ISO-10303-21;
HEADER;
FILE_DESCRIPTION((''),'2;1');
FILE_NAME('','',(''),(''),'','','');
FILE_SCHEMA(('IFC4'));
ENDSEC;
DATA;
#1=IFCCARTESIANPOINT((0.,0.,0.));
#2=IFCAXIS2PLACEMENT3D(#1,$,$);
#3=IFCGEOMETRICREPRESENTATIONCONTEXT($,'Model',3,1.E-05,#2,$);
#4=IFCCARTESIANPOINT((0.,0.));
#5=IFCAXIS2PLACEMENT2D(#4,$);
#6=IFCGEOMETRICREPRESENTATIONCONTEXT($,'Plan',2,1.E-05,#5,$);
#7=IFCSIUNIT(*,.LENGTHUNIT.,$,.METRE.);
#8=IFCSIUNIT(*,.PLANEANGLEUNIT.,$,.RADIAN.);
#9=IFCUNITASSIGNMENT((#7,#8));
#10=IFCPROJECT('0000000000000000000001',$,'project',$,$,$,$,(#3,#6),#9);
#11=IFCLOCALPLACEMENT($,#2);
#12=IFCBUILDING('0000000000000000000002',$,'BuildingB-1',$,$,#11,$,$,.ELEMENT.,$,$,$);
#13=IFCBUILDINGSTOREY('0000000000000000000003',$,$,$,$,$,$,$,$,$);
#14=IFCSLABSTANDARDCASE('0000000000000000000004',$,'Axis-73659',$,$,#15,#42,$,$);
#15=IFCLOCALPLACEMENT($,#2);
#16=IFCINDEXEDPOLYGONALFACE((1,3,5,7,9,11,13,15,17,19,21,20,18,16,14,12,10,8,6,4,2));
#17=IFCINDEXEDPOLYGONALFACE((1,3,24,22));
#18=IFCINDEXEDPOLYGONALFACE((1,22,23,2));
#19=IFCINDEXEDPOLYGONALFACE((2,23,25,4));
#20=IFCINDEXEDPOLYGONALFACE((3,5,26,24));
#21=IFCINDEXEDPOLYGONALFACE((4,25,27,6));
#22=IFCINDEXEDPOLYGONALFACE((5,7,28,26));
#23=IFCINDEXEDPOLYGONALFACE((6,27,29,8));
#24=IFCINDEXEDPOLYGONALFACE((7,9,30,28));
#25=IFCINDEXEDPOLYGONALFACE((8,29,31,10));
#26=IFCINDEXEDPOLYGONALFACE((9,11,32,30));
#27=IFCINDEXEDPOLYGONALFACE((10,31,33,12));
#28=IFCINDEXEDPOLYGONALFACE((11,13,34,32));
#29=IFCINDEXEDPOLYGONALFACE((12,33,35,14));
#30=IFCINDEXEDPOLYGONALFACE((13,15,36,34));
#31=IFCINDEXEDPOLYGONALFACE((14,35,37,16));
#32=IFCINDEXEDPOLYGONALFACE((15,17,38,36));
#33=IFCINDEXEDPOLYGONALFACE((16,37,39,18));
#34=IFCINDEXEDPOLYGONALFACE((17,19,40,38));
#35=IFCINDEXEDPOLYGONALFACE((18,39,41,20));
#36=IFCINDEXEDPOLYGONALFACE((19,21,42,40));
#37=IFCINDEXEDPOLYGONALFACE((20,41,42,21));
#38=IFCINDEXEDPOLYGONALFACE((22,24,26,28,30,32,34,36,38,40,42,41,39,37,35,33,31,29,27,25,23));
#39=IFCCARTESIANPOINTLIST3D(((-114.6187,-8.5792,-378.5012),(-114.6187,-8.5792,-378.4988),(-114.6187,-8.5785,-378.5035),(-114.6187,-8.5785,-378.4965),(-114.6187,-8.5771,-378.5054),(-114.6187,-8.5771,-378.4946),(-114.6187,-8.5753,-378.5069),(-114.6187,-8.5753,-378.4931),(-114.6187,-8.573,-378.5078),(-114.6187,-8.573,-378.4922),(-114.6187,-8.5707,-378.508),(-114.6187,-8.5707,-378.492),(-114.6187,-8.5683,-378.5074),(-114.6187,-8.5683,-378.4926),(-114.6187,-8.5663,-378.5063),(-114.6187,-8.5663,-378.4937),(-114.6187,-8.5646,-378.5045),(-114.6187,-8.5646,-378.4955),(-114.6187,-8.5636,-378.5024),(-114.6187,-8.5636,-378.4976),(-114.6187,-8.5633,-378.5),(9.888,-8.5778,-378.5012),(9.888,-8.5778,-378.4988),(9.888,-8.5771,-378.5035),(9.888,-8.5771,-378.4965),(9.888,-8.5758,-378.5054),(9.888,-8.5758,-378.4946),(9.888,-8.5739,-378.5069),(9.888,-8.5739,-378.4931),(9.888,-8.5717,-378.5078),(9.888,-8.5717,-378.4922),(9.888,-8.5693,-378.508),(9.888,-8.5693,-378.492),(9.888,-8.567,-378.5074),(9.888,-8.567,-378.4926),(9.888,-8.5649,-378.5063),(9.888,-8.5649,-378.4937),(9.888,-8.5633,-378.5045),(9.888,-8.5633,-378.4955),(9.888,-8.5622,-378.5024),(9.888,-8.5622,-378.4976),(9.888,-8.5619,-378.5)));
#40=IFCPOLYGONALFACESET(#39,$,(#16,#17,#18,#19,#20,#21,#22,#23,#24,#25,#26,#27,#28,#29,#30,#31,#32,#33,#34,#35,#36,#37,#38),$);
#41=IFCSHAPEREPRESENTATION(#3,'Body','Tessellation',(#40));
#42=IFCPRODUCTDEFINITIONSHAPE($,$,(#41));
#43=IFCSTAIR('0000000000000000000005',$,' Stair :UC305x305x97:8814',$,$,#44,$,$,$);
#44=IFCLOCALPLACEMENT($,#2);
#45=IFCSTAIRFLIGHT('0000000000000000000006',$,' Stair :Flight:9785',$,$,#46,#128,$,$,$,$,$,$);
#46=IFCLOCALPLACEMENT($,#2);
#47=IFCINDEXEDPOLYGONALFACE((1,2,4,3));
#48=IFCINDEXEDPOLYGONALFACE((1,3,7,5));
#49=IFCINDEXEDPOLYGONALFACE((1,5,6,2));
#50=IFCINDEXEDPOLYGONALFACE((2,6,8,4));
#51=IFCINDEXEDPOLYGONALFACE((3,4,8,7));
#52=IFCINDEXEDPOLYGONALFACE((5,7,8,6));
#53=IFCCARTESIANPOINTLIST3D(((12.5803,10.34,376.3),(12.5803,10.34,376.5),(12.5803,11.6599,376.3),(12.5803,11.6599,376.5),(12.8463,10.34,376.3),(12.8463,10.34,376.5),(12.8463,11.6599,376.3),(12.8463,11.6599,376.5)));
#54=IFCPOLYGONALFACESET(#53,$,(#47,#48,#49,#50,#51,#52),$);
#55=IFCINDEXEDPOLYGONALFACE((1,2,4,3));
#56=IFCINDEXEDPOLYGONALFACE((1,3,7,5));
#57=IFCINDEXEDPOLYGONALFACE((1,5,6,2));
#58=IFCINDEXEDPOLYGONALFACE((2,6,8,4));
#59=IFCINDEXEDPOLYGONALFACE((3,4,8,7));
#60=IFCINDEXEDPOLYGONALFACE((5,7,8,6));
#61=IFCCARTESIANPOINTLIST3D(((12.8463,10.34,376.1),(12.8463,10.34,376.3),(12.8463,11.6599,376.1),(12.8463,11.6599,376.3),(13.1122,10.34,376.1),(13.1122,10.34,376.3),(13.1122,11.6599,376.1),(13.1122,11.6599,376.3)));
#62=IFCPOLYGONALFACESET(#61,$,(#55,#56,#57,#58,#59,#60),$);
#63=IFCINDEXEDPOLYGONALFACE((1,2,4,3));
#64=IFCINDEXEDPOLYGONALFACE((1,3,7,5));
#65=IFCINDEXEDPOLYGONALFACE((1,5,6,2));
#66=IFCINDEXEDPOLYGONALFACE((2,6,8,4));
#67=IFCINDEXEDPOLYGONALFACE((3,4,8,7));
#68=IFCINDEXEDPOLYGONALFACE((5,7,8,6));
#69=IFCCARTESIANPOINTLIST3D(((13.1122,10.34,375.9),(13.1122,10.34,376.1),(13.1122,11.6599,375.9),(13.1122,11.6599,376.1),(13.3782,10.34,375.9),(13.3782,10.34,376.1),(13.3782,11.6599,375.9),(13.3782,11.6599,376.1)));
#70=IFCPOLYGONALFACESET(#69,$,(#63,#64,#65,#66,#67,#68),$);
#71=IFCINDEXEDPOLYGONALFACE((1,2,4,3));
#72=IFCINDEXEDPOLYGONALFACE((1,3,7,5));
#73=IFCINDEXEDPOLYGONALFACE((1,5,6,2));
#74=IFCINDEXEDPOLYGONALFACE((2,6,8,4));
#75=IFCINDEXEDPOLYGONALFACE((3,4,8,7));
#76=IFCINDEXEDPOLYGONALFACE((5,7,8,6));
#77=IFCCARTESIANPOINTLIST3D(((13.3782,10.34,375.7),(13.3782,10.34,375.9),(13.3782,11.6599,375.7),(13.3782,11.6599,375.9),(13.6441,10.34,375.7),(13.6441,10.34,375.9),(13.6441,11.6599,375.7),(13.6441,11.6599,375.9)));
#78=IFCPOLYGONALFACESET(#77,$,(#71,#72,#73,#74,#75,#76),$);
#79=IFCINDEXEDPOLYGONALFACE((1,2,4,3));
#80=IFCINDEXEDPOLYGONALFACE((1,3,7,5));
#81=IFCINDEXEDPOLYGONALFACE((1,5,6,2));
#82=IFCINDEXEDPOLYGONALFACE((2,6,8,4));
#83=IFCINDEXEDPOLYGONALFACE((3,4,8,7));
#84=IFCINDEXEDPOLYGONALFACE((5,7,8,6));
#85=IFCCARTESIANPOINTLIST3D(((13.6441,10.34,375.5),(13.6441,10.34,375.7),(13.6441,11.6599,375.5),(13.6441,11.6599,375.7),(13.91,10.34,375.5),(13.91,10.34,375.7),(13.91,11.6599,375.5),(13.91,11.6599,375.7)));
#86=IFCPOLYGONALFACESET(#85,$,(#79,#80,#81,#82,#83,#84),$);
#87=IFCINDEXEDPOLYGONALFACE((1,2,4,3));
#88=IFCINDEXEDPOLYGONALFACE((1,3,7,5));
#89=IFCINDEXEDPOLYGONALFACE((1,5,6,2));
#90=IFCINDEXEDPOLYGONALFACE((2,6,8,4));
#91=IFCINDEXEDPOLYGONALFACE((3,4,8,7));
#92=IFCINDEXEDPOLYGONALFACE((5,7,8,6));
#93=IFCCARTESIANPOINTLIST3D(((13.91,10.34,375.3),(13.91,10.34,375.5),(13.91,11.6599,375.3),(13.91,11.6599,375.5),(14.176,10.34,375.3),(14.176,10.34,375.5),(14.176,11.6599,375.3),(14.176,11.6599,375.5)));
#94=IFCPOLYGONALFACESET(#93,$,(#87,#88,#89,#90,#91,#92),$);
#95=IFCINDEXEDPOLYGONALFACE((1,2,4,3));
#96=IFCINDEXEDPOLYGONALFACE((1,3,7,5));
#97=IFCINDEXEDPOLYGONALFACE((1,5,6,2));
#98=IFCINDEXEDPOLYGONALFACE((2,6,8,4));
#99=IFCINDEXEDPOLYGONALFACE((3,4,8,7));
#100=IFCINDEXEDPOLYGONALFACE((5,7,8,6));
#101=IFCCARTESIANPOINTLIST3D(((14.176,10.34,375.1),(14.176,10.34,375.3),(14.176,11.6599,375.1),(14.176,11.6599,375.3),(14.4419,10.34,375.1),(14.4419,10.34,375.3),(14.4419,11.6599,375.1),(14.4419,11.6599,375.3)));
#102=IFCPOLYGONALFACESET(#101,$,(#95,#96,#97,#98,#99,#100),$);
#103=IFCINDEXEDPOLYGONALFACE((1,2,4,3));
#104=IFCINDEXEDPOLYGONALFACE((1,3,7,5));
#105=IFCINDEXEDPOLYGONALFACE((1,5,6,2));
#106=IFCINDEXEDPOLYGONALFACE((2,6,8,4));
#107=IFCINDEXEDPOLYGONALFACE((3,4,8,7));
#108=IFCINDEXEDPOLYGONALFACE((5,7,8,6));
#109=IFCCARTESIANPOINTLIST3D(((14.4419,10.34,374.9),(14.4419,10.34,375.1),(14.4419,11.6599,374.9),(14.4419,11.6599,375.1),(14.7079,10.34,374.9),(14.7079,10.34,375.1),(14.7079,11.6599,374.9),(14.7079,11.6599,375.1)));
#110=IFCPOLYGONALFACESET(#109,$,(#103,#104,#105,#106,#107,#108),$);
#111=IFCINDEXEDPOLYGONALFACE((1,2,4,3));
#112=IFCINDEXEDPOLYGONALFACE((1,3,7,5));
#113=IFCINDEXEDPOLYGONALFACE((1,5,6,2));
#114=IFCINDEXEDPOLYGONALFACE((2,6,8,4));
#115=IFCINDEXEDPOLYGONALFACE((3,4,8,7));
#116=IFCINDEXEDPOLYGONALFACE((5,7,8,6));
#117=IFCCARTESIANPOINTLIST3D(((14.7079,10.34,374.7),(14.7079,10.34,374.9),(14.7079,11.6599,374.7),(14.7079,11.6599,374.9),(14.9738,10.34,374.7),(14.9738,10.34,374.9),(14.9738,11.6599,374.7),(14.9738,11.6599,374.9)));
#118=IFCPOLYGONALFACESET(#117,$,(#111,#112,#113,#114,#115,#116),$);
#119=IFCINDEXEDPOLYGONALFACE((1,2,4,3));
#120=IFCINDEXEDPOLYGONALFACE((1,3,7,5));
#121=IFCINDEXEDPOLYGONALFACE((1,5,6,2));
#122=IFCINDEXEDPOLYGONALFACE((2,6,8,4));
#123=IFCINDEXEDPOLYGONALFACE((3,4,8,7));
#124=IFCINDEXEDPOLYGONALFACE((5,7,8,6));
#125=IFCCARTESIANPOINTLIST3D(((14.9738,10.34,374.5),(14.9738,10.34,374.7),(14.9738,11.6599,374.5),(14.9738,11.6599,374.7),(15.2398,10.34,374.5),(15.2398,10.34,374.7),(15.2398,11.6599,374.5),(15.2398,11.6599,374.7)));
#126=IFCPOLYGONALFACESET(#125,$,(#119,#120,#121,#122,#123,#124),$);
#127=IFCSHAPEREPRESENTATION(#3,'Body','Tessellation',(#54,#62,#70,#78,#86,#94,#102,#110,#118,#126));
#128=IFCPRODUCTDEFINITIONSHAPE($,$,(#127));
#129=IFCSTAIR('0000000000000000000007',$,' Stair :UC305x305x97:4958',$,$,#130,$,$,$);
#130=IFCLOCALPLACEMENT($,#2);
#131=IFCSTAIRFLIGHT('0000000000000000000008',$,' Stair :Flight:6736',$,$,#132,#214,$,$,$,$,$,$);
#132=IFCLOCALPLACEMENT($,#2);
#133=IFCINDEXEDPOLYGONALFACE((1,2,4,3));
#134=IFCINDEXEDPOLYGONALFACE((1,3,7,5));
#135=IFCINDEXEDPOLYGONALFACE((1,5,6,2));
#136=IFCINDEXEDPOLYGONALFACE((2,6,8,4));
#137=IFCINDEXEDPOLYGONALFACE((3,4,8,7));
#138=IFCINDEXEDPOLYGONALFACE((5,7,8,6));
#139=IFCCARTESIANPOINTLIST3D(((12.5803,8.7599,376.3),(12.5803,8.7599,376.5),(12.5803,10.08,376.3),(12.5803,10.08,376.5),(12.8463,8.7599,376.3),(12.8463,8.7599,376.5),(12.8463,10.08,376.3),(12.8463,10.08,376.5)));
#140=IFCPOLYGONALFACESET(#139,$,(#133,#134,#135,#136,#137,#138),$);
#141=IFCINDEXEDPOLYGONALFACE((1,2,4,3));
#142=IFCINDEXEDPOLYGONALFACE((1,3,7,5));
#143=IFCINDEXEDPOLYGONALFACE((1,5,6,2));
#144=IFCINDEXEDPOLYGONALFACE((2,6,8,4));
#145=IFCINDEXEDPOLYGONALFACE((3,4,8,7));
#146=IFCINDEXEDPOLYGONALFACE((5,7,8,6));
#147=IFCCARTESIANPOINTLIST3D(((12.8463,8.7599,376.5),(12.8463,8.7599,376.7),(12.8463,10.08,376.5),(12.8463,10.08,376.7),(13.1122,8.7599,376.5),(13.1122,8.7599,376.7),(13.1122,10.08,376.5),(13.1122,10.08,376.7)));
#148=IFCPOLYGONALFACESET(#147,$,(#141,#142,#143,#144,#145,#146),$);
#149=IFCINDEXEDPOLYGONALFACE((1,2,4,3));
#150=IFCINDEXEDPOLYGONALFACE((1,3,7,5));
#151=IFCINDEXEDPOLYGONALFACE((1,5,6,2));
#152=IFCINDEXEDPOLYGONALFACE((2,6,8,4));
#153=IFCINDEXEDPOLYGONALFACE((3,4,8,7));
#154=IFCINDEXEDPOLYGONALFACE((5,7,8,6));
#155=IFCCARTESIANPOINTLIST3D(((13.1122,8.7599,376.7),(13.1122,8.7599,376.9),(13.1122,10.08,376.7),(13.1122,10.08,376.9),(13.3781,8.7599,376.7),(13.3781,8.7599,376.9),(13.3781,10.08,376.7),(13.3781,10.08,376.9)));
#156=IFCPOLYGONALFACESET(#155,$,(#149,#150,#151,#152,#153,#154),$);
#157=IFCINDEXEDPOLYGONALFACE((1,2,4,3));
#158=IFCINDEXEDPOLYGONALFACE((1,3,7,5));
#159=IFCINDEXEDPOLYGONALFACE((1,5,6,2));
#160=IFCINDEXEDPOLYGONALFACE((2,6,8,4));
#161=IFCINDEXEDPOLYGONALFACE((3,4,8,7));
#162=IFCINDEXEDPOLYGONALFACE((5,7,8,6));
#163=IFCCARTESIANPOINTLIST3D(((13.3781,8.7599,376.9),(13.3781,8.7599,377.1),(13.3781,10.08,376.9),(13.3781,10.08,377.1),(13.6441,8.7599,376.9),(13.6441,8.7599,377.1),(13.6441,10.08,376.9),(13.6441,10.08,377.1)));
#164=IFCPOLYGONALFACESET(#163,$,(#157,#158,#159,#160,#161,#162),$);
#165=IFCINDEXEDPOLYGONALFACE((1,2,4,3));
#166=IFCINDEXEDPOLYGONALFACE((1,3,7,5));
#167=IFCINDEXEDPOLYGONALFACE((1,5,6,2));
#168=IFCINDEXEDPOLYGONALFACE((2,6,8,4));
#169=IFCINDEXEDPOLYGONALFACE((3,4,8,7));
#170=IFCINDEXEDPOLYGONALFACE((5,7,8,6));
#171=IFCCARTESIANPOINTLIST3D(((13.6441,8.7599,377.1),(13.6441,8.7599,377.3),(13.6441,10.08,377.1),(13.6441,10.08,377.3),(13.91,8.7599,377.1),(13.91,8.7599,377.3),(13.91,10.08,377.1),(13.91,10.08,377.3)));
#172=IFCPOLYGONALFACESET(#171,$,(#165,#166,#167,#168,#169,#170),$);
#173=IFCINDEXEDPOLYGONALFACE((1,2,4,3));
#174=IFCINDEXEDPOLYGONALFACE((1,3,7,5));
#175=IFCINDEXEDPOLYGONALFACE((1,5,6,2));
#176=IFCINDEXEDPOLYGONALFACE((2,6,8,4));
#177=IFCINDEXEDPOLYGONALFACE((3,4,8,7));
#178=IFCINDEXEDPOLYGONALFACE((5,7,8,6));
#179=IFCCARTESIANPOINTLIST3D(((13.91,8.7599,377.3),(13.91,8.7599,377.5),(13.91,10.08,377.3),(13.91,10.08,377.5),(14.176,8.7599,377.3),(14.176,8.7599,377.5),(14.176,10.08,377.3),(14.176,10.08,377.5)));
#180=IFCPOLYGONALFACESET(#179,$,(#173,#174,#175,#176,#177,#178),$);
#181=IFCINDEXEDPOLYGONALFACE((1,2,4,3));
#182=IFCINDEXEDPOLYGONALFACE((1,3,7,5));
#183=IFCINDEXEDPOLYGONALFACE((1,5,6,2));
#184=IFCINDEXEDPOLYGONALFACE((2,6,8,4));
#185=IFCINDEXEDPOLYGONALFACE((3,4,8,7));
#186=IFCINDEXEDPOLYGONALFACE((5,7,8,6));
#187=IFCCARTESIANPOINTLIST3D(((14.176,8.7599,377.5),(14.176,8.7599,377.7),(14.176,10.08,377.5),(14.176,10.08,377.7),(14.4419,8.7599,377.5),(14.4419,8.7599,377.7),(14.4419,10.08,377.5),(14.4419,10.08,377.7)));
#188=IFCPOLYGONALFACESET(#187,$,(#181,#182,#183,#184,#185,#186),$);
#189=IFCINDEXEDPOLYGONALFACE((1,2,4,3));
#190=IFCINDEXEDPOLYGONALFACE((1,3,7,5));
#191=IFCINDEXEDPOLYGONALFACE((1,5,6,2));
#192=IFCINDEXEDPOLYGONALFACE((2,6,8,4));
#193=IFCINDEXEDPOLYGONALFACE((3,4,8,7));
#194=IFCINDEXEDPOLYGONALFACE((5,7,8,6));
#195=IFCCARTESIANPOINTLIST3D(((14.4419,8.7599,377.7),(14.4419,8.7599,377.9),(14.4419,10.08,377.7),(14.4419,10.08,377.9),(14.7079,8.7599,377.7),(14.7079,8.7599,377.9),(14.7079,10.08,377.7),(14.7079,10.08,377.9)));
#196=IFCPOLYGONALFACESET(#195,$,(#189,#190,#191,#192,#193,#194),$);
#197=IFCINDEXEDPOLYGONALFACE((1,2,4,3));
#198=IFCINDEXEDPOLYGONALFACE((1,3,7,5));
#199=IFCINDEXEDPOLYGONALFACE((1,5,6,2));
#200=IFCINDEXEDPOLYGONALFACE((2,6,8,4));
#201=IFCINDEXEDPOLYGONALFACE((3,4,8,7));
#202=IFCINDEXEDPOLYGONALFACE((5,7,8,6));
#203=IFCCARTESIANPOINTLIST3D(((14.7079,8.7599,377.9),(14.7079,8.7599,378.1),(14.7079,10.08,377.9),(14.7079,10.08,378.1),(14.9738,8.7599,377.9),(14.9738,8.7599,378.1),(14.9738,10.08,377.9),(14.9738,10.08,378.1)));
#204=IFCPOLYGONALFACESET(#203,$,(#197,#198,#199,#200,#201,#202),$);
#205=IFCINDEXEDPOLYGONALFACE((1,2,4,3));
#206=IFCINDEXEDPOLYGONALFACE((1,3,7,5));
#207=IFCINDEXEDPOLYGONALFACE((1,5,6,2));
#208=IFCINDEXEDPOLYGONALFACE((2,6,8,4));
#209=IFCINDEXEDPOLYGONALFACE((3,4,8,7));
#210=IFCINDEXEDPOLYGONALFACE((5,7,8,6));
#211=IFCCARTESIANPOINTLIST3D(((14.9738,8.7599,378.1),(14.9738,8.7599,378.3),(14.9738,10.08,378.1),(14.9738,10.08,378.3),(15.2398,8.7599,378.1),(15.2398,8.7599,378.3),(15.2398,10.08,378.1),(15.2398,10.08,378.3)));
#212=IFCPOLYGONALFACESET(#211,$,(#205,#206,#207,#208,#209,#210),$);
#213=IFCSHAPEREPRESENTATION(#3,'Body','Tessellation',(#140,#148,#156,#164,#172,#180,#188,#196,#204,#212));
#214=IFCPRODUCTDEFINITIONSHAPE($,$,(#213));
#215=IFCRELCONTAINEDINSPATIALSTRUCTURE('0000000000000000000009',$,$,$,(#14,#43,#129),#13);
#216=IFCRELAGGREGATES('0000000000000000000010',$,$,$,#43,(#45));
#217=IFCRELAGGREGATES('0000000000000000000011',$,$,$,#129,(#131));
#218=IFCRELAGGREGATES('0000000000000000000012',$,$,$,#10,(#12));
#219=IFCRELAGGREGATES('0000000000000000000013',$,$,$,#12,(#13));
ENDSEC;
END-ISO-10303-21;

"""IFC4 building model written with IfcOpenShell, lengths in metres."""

from ifc_helpers import new_model, entity, si_unit, frame, origin, origin_2d, place, context, project, spatial, polyline, outline, extrude, element, aggregate, save


model = new_model("IFC4")

# Units and contexts
model_context = context("Model", 3, precision=1e-05, world=origin())
plan_context = context("Plan", 2, precision=1e-05, world=origin_2d())
ifc_project = project(units=[si_unit("LENGTHUNIT", "METRE"), si_unit("PLANEANGLEUNIT", "RADIAN")], contexts=[model_context, plan_context])

# Building, storey
building_placement = place(None, origin())
building = spatial("IfcBuilding", under=ifc_project, at=building_placement, Name="BuildingB-1", CompositionType="ELEMENT")
storey = spatial("IfcBuildingStorey", under=building)

# Slab
element("IfcSlabStandardCase", 1, inside=storey, Name="Axis-73659", context=model_context, shape_type="AdvancedSweptSolid", body=[
    entity("IfcSurfaceCurveSweptAreaSolid", entity("IfcCircleProfileDef", "AREA", None, None, 0.008), None, entity("IfcPolyline", [entity("IfcCartesianPoint", [-9.888, 8.5699, 378.5]), entity("IfcCartesianPoint", [114.6187, 8.5713, 378.5])]), None, None, entity("IfcPlane", entity("IfcAxis2Placement3D", entity("IfcCartesianPoint", [-9.888, 8.5699, 378.5]), entity("IfcDirection", [0.0, 0.0, 1.0]), entity("IfcDirection", [1.0, 0.0, 0.0])))),
    entity("IfcSurfaceCurveSweptAreaSolid", entity("IfcCircleProfileDef", "AREA", None, None, 0.008), None, entity("IfcCircle", entity("IfcAxis2Placement2D", entity("IfcCartesianPoint", [-10.1215, 8.5699, 378.5])), 0.35), None, None, entity("IfcPlane", entity("IfcAxis2Placement3D", entity("IfcCartesianPoint", [-10.1215, 8.5699, 378.5]), entity("IfcDirection", [0.0, 0.0, 1.0]), entity("IfcDirection", [1.0, 0.0, 0.0])))),
    entity("IfcSurfaceCurveSweptAreaSolid", entity("IfcCircleProfileDef", "AREA", None, None, 0.008), None, entity("IfcCircle", entity("IfcAxis2Placement2D", entity("IfcCartesianPoint", [114.8522, 8.5713, 378.5])), 0.35), None, None, entity("IfcPlane", entity("IfcAxis2Placement3D", entity("IfcCartesianPoint", [114.8522, 8.5713, 378.5]), entity("IfcDirection", [0.0, 0.0, 1.0]), entity("IfcDirection", [1.0, 0.0, 0.0])))),
])

# Stairs, stair flights
stair_1 = element("IfcStair", 2, inside=storey, Name=" Stair :UC305x305x97:8814")
stair_flight_1 = element("IfcStairFlight", 3, Name=" Stair :Flight:9785", context=model_context, shape_type="SweptSolid", body=[
    extrude(outline(polyline([(12.8463, 11.6599, 376.5), (12.8463, 10.34, 376.5), (12.5803, 10.34, 376.5), (12.5803, 11.6599, 376.5), (12.8463, 11.6599, 376.5)])), origin(), (0.0, 0.0, -1.0), 0.2),
    extrude(outline(polyline([(13.1122, 11.6599, 376.5), (13.1122, 10.34, 376.5), (12.8463, 10.34, 376.5), (12.8463, 11.6599, 376.5), (13.1122, 11.6599, 376.5)])), frame((0.0, 0.0, -0.2)), (0.0, 0.0, -1.0), 0.2),
    extrude(outline(polyline([(13.3782, 11.6599, 376.5), (13.3782, 10.34, 376.5), (13.1122, 10.34, 376.5), (13.1122, 11.6599, 376.5), (13.3782, 11.6599, 376.5)])), frame((0.0, 0.0, -0.4)), (0.0, 0.0, -1.0), 0.2),
    extrude(outline(polyline([(13.6441, 11.6599, 376.5), (13.6441, 10.34, 376.5), (13.3782, 10.34, 376.5), (13.3782, 11.6599, 376.5), (13.6441, 11.6599, 376.5)])), frame((0.0, 0.0, -0.6)), (0.0, 0.0, -1.0), 0.2),
    extrude(outline(polyline([(13.91, 11.6599, 376.5), (13.91, 10.34, 376.5), (13.6441, 10.34, 376.5), (13.6441, 11.6599, 376.5), (13.91, 11.6599, 376.5)])), frame((0.0, 0.0, -0.8)), (0.0, 0.0, -1.0), 0.2),
    extrude(outline(polyline([(14.176, 11.6599, 376.5), (14.176, 10.34, 376.5), (13.91, 10.34, 376.5), (13.91, 11.6599, 376.5), (14.176, 11.6599, 376.5)])), frame((0.0, 0.0, -1.0)), (0.0, 0.0, -1.0), 0.2),
    extrude(outline(polyline([(14.4419, 11.6599, 376.5), (14.4419, 10.34, 376.5), (14.176, 10.34, 376.5), (14.176, 11.6599, 376.5), (14.4419, 11.6599, 376.5)])), frame((0.0, 0.0, -1.2)), (0.0, 0.0, -1.0), 0.2),
    extrude(outline(polyline([(14.7079, 11.6599, 376.5), (14.7079, 10.34, 376.5), (14.4419, 10.34, 376.5), (14.4419, 11.6599, 376.5), (14.7079, 11.6599, 376.5)])), frame((0.0, 0.0, -1.4)), (0.0, 0.0, -1.0), 0.2),
    extrude(outline(polyline([(14.9738, 11.6599, 376.5), (14.9738, 10.34, 376.5), (14.7079, 10.34, 376.5), (14.7079, 11.6599, 376.5), (14.9738, 11.6599, 376.5)])), frame((0.0, 0.0, -1.6)), (0.0, 0.0, -1.0), 0.2),
    extrude(outline(polyline([(15.2398, 11.6599, 376.5), (15.2398, 10.34, 376.5), (14.9738, 10.34, 376.5), (14.9738, 11.6599, 376.5), (15.2398, 11.6599, 376.5)])), frame((0.0, 0.0, -1.8)), (0.0, 0.0, -1.0), 0.2),
])
aggregate(stair_1, [stair_flight_1])
stair_2 = element("IfcStair", 4, inside=storey, Name=" Stair :UC305x305x97:4958")
stair_flight_2 = element("IfcStairFlight", 5, Name=" Stair :Flight:6736", context=model_context, shape_type="SweptSolid", body=[
    extrude(outline(polyline([(12.8463, 8.7599, 376.5), (12.8463, 10.08, 376.5), (12.5803, 10.08, 376.5), (12.5803, 8.7599, 376.5), (12.8463, 8.7599, 376.5)])), origin(), (0.0, 0.0, -1.0), 0.2),
    extrude(outline(polyline([(13.1122, 8.7599, 376.5), (13.1122, 10.08, 376.5), (12.8463, 10.08, 376.5), (12.8463, 8.7599, 376.5), (13.1122, 8.7599, 376.5)])), frame((0.0, 0.0, 0.2)), (0.0, 0.0, -1.0), 0.2),
    extrude(outline(polyline([(13.3781, 8.7599, 376.5), (13.3781, 10.08, 376.5), (13.1122, 10.08, 376.5), (13.1122, 8.7599, 376.5), (13.3781, 8.7599, 376.5)])), frame((0.0, 0.0, 0.4)), (0.0, 0.0, -1.0), 0.2),
    extrude(outline(polyline([(13.6441, 8.7599, 376.5), (13.6441, 10.08, 376.5), (13.3781, 10.08, 376.5), (13.3781, 8.7599, 376.5), (13.6441, 8.7599, 376.5)])), frame((0.0, 0.0, 0.6)), (0.0, 0.0, -1.0), 0.2),
    extrude(outline(polyline([(13.91, 8.7599, 376.5), (13.91, 10.08, 376.5), (13.6441, 10.08, 376.5), (13.6441, 8.7599, 376.5), (13.91, 8.7599, 376.5)])), frame((0.0, 0.0, 0.8)), (0.0, 0.0, -1.0), 0.2),
    extrude(outline(polyline([(14.176, 8.7599, 376.5), (14.176, 10.08, 376.5), (13.91, 10.08, 376.5), (13.91, 8.7599, 376.5), (14.176, 8.7599, 376.5)])), frame((0.0, 0.0, 1.0)), (0.0, 0.0, -1.0), 0.2),
    extrude(outline(polyline([(14.4419, 8.7599, 376.5), (14.4419, 10.08, 376.5), (14.176, 10.08, 376.5), (14.176, 8.7599, 376.5), (14.4419, 8.7599, 376.5)])), frame((0.0, 0.0, 1.2)), (0.0, 0.0, -1.0), 0.2),
    extrude(outline(polyline([(14.7079, 8.7599, 376.5), (14.7079, 10.08, 376.5), (14.4419, 10.08, 376.5), (14.4419, 8.7599, 376.5), (14.7079, 8.7599, 376.5)])), frame((0.0, 0.0, 1.4)), (0.0, 0.0, -1.0), 0.2),
    extrude(outline(polyline([(14.9738, 8.7599, 376.5), (14.9738, 10.08, 376.5), (14.7079, 10.08, 376.5), (14.7079, 8.7599, 376.5), (14.9738, 8.7599, 376.5)])), frame((0.0, 0.0, 1.6)), (0.0, 0.0, -1.0), 0.2),
    extrude(outline(polyline([(15.2398, 8.7599, 376.5), (15.2398, 10.08, 376.5), (14.9738, 10.08, 376.5), (14.9738, 8.7599, 376.5), (15.2398, 8.7599, 376.5)])), frame((0.0, 0.0, 1.8)), (0.0, 0.0, -1.0), 0.2),
])
aggregate(stair_2, [stair_flight_2])

save(model, "model.ifc")
